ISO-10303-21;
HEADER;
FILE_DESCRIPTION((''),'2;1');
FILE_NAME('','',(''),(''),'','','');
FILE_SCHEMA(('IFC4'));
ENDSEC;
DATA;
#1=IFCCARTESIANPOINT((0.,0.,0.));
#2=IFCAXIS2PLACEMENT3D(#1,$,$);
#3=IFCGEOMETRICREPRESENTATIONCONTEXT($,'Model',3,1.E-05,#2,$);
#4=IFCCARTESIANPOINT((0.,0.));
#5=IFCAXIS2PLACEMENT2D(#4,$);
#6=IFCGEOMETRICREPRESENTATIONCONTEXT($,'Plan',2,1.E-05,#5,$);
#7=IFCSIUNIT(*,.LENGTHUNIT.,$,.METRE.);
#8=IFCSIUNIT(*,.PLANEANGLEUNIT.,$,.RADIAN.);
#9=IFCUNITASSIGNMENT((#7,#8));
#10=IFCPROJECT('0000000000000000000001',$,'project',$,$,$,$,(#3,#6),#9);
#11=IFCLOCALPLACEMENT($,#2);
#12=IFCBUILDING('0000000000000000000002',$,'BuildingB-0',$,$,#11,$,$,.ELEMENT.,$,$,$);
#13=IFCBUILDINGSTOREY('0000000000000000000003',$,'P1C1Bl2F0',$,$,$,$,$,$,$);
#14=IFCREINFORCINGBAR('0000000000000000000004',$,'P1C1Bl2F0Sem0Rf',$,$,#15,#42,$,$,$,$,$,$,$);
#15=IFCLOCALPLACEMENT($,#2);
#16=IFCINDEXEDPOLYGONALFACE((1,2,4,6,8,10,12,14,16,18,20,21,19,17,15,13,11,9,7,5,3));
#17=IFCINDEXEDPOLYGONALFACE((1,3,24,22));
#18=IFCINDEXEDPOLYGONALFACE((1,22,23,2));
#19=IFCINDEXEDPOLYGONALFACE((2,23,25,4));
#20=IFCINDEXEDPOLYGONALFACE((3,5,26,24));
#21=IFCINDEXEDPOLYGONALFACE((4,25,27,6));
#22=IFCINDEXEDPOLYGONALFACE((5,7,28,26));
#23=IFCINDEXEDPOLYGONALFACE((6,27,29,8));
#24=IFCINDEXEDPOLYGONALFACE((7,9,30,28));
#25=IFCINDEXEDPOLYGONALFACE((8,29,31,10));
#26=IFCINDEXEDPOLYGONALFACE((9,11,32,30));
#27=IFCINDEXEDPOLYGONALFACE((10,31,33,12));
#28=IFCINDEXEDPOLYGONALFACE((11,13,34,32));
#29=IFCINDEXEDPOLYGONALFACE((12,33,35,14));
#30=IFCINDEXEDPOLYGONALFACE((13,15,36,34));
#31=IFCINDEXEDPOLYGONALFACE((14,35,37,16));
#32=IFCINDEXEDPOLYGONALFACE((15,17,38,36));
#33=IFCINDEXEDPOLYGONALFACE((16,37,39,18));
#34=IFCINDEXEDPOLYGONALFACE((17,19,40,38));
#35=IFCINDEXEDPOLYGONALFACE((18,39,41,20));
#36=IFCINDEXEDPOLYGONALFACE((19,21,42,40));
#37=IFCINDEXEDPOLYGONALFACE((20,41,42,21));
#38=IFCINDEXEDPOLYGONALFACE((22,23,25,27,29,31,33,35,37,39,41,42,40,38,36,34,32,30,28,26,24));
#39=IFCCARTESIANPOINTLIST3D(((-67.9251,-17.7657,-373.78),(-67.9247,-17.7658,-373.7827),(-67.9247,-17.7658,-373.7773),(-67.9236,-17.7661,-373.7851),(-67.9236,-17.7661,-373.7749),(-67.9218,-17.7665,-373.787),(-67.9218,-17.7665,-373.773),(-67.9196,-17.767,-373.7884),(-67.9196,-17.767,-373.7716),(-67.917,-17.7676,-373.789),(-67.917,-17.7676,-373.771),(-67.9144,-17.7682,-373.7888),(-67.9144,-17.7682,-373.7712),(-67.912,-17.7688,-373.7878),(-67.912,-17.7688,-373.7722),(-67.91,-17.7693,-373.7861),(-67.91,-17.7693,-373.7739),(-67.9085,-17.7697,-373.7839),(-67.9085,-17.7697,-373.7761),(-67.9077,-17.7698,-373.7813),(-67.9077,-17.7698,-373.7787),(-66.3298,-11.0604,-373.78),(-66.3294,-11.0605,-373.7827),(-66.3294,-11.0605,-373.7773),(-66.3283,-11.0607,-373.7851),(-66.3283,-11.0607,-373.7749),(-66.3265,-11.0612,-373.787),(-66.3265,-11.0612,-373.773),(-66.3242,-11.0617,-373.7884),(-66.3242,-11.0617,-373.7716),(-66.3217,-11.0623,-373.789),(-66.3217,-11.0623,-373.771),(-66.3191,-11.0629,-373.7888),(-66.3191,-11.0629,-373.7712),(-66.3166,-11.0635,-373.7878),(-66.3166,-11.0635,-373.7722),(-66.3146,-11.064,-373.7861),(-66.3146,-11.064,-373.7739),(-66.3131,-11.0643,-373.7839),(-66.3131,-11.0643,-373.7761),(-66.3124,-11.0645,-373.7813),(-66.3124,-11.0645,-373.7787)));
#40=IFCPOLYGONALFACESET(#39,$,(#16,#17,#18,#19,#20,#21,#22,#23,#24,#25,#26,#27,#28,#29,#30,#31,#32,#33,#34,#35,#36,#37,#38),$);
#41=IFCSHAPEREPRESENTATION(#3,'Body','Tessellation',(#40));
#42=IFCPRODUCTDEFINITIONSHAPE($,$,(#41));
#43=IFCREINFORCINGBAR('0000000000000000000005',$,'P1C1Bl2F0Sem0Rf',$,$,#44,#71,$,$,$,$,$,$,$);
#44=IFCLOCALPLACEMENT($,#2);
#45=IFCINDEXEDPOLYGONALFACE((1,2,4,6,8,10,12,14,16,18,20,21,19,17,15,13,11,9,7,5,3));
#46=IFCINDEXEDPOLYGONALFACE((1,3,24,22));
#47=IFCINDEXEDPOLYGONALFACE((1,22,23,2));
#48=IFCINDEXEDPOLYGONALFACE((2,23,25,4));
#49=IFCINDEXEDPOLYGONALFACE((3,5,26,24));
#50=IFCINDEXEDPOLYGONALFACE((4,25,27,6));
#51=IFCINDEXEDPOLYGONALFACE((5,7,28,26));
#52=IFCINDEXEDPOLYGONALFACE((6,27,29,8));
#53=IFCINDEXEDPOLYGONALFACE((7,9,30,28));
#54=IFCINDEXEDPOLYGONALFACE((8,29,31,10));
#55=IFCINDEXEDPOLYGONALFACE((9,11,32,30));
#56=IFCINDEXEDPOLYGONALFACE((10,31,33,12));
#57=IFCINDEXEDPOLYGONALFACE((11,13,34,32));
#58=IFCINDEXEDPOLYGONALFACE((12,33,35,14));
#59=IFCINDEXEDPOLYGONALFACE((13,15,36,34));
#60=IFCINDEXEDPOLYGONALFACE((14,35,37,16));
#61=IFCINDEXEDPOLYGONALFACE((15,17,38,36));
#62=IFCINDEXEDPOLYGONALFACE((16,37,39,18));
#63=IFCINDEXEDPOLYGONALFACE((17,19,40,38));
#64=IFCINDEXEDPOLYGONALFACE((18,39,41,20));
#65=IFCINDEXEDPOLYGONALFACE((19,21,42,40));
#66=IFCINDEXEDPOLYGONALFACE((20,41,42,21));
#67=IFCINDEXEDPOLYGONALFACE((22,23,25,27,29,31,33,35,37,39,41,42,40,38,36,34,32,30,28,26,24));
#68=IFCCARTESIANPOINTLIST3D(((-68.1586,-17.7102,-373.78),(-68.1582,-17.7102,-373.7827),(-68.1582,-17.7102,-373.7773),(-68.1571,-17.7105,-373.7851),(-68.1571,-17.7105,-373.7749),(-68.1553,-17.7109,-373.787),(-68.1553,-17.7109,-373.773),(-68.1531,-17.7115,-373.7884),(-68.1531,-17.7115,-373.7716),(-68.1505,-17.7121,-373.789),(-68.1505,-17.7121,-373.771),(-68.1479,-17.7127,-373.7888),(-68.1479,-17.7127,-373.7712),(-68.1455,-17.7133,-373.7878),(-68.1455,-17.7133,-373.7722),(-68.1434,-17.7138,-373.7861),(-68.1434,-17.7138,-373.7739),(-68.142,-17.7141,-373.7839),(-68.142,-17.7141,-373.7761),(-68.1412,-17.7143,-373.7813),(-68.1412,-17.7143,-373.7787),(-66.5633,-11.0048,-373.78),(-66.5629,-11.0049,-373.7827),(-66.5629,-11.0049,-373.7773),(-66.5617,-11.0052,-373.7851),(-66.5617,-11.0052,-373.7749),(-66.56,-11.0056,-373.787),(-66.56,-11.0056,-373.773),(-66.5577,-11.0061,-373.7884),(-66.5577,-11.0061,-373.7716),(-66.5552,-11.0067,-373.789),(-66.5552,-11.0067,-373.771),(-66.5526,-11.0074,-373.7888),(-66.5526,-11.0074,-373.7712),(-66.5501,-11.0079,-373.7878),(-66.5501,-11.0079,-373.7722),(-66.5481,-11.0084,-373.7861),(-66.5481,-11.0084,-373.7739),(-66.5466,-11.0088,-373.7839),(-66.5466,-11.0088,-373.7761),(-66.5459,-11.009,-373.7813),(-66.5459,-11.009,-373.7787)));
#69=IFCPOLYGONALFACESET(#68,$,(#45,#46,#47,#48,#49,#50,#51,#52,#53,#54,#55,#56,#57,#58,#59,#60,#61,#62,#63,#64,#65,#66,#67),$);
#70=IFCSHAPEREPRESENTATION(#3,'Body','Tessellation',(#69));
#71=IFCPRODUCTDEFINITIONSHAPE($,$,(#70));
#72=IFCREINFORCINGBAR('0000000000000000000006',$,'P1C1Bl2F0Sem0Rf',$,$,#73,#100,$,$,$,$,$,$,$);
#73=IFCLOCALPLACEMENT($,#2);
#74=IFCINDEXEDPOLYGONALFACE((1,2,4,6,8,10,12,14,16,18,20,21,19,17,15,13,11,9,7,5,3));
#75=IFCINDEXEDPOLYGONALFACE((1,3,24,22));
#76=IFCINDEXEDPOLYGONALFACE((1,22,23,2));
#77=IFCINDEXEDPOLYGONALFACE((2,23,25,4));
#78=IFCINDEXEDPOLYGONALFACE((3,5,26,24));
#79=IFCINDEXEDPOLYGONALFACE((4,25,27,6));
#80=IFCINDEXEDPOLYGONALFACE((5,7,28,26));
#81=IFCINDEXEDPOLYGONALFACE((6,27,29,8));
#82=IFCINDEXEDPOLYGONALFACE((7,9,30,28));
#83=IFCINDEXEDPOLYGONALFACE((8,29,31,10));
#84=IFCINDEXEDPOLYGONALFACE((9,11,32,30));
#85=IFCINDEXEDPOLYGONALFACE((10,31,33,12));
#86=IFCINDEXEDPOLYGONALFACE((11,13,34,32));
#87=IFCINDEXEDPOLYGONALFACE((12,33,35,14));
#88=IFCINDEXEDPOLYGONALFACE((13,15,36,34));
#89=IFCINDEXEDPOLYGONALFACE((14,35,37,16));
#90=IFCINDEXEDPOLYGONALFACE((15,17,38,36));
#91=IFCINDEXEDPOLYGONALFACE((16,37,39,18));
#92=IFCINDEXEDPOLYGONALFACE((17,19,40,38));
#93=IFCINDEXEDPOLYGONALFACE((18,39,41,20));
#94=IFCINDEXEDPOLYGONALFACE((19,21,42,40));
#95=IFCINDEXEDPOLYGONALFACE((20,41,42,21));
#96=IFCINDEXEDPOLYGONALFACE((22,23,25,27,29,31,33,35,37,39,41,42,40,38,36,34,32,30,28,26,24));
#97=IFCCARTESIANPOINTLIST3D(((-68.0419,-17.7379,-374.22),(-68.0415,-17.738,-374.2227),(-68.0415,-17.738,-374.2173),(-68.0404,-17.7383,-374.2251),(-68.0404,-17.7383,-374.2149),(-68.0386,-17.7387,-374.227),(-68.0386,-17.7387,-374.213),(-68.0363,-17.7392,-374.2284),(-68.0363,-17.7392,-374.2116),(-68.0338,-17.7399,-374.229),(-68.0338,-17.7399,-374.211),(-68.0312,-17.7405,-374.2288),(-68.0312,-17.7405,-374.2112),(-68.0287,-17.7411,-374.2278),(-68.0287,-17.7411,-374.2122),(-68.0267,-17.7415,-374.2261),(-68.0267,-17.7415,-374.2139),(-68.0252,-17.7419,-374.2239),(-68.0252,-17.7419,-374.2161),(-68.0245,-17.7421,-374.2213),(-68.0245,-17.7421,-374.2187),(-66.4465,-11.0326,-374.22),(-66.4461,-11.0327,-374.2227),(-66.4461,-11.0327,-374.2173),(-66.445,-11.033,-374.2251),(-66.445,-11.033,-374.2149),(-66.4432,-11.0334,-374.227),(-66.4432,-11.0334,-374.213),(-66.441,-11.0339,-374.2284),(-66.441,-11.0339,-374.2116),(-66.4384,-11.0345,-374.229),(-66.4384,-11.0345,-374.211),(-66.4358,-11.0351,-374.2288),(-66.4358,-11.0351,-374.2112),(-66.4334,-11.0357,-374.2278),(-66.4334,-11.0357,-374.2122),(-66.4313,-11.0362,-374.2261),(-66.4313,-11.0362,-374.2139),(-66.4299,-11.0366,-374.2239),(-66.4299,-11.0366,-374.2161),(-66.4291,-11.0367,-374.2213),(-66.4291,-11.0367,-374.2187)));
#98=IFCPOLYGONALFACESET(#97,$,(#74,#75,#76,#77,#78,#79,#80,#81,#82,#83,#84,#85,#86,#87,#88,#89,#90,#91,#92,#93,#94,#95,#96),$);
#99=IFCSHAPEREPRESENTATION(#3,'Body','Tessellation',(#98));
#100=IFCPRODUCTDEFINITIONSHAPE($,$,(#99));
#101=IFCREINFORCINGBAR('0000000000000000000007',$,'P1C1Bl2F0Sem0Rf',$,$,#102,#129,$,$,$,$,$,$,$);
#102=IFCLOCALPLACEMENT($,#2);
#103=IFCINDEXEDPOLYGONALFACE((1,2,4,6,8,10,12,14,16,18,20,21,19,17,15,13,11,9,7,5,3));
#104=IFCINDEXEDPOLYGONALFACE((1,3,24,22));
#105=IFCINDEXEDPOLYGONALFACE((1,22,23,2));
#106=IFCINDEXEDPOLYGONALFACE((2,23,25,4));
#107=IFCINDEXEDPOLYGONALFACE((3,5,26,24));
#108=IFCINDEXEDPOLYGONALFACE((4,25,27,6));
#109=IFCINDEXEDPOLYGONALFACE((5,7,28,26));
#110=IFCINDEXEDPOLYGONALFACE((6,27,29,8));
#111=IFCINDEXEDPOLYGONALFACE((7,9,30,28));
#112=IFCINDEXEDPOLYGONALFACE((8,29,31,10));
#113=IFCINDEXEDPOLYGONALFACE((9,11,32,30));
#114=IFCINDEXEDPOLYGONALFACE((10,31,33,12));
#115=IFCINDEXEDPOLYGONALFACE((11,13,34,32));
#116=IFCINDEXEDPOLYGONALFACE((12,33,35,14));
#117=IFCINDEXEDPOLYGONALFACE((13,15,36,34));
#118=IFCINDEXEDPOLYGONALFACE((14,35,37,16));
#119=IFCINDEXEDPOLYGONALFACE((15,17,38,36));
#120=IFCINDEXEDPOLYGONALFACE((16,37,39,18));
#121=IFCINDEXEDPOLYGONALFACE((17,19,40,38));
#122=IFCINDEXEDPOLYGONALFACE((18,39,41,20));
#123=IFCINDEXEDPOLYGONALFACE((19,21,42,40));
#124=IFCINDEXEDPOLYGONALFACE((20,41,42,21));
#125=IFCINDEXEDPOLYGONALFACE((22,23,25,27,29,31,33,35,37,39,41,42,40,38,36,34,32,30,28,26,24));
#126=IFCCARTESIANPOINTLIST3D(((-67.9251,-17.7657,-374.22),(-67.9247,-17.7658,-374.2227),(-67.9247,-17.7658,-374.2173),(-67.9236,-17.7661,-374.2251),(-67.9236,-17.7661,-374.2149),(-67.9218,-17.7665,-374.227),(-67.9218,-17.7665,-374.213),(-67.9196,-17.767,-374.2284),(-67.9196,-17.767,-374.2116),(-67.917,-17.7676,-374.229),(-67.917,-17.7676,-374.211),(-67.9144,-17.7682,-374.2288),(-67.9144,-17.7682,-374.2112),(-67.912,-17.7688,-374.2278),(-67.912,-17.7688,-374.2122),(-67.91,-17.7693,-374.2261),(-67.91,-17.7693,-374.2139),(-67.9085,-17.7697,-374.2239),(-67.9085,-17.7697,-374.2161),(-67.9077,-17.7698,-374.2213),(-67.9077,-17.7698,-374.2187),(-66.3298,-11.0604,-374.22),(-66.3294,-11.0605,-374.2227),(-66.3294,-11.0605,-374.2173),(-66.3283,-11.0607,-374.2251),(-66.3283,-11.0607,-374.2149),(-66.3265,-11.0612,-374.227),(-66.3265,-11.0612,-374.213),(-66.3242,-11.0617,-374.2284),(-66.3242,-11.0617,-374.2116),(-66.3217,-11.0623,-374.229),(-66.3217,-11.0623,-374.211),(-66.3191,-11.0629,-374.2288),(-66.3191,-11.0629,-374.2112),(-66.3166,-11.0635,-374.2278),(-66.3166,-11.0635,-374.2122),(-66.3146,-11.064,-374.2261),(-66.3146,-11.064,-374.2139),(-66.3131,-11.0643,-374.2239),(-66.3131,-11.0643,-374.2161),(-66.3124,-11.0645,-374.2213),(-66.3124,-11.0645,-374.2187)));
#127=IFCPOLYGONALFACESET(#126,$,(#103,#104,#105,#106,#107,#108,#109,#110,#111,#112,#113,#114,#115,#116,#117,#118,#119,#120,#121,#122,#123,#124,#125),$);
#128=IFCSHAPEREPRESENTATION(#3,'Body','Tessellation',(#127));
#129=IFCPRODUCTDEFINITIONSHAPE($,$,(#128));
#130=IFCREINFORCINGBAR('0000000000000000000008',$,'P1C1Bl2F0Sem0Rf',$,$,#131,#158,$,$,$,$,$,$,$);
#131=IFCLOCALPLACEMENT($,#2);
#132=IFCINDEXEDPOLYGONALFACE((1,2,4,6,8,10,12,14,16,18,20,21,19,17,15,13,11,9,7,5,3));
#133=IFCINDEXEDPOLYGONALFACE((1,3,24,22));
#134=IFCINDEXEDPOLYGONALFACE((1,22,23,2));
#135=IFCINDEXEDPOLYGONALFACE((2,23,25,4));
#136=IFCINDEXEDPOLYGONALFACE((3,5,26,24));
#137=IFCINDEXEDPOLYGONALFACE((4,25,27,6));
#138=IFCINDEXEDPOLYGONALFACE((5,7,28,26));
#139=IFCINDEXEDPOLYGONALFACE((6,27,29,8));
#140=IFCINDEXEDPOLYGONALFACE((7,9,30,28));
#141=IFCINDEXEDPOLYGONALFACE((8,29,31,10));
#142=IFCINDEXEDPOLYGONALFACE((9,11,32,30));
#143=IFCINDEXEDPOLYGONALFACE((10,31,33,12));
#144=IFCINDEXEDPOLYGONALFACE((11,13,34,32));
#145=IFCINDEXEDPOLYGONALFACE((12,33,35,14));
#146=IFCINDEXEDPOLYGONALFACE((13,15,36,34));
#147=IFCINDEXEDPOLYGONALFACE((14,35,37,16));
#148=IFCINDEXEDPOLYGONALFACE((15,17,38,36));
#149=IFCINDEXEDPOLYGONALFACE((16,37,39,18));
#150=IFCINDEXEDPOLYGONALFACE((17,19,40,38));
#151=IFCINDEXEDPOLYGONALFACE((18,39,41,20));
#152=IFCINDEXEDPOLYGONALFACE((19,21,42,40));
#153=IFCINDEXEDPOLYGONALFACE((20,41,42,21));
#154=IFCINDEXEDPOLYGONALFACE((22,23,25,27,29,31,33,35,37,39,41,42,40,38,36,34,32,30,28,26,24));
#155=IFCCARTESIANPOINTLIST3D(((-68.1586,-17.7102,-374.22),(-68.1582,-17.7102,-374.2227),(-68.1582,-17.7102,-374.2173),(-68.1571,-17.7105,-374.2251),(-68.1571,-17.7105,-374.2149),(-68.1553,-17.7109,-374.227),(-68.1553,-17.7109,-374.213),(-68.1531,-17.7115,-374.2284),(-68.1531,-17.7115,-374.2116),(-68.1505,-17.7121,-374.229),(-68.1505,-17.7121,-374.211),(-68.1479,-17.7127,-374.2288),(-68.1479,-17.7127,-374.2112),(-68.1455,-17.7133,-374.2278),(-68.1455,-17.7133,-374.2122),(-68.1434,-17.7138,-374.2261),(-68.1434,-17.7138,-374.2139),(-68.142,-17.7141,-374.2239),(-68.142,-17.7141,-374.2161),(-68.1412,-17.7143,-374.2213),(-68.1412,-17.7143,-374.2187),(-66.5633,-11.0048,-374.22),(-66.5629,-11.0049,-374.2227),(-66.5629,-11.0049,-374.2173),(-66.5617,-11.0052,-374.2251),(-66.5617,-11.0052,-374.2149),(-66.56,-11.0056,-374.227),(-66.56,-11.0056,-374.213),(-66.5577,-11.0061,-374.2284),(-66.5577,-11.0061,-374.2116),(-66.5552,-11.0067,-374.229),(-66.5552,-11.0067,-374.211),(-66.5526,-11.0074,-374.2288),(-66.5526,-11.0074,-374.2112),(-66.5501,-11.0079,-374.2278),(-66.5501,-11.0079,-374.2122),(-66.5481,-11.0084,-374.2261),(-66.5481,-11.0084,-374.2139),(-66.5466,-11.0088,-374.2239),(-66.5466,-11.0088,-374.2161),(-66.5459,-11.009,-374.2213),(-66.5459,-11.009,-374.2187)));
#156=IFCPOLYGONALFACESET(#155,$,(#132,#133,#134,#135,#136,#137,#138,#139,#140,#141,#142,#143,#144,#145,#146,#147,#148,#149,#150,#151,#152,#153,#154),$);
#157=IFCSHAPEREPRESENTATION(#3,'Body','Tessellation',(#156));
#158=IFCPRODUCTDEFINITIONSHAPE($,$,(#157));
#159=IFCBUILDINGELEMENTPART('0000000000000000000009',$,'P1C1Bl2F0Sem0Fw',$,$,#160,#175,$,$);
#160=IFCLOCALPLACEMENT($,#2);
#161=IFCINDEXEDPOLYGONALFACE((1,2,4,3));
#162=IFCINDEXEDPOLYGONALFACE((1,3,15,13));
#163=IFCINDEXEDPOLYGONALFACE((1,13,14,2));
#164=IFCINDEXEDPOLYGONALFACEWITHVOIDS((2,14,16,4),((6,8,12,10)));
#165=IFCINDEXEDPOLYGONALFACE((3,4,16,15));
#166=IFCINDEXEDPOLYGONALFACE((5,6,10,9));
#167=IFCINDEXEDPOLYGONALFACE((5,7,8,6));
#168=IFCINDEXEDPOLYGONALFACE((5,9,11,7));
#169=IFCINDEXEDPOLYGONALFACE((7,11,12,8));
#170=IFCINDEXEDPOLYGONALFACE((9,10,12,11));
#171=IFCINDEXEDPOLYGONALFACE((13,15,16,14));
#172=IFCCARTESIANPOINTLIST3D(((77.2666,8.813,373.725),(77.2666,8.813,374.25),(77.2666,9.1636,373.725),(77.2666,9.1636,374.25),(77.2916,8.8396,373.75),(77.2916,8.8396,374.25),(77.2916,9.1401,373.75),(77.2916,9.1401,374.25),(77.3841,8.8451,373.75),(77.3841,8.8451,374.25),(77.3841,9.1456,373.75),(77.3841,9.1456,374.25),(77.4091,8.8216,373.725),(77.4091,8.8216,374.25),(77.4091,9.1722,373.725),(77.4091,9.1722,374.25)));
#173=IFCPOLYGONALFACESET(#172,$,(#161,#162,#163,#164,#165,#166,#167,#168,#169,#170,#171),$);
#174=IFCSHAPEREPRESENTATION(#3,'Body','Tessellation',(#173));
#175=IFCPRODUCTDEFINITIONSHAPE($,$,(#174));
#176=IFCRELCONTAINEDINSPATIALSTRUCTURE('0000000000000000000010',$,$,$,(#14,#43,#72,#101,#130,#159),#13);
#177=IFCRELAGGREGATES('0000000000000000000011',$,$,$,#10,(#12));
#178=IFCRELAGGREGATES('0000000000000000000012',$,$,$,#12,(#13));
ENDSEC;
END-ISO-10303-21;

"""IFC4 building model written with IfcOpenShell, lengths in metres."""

from ifc_helpers import new_model, entity, si_unit, origin, origin_2d, place, context, project, spatial, polyline, outline, extrude, element, save


model = new_model("IFC4")

# Units and contexts
model_context = context("Model", 3, precision=1e-05, world=origin())
plan_context = context("Plan", 2, precision=1e-05, world=origin_2d())
ifc_project = project(units=[si_unit("LENGTHUNIT", "METRE"), si_unit("PLANEANGLEUNIT", "RADIAN")], contexts=[model_context, plan_context])

# Building, storey
building_placement = place(None, origin())
building = spatial("IfcBuilding", under=ifc_project, at=building_placement, Name="BuildingB-0", CompositionType="ELEMENT")
storey = spatial("IfcBuildingStorey", under=building, Name="P1C1Bl2F0")

# Reinforcing bars
element("IfcReinforcingBar", 1, inside=storey, Name="P1C1Bl2F0Sem0Rf", context=model_context, shape_type="SweptSolid", body=[
    entity("IfcSurfaceCurveSweptAreaSolid", entity("IfcCircleProfileDef", "AREA", None, None, 0.009), None, entity("IfcPolyline", [entity("IfcCartesianPoint", [67.9164, 17.7678, 373.78]), entity("IfcCartesianPoint", [66.321, 11.0625, 373.78])]), None, None, entity("IfcPlane", entity("IfcAxis2Placement3D", entity("IfcCartesianPoint", [67.9164, 17.7678, 373.78]), entity("IfcDirection", [0.0, 0.0, 1.0]), entity("IfcDirection", [1.0, 0.0, 0.0])))),
])
element("IfcReinforcingBar", 2, inside=storey, Name="P1C1Bl2F0Sem0Rf", context=model_context, shape_type="SweptSolid", body=[
    entity("IfcSurfaceCurveSweptAreaSolid", entity("IfcCircleProfileDef", "AREA", None, None, 0.009), None, entity("IfcPolyline", [entity("IfcCartesianPoint", [68.1499, 17.7122, 373.78]), entity("IfcCartesianPoint", [66.5545, 11.0069, 373.78])]), None, None, entity("IfcPlane", entity("IfcAxis2Placement3D", entity("IfcCartesianPoint", [68.1499, 17.7122, 373.78]), entity("IfcDirection", [0.0, 0.0, 1.0]), entity("IfcDirection", [1.0, 0.0, 0.0])))),
])
element("IfcReinforcingBar", 3, inside=storey, Name="P1C1Bl2F0Sem0Rf", context=model_context, shape_type="SweptSolid", body=[
    entity("IfcSurfaceCurveSweptAreaSolid", entity("IfcCircleProfileDef", "AREA", None, None, 0.009), None, entity("IfcPolyline", [entity("IfcCartesianPoint", [68.0331, 17.74, 374.22]), entity("IfcCartesianPoint", [66.4378, 11.0347, 374.22])]), None, None, entity("IfcPlane", entity("IfcAxis2Placement3D", entity("IfcCartesianPoint", [68.0331, 17.74, 374.22]), entity("IfcDirection", [0.0, 0.0, 1.0]), entity("IfcDirection", [1.0, 0.0, 0.0])))),
])
element("IfcReinforcingBar", 4, inside=storey, Name="P1C1Bl2F0Sem0Rf", context=model_context, shape_type="SweptSolid", body=[
    entity("IfcSurfaceCurveSweptAreaSolid", entity("IfcCircleProfileDef", "AREA", None, None, 0.009), None, entity("IfcPolyline", [entity("IfcCartesianPoint", [67.9164, 17.7678, 374.22]), entity("IfcCartesianPoint", [66.321, 11.0625, 374.22])]), None, None, entity("IfcPlane", entity("IfcAxis2Placement3D", entity("IfcCartesianPoint", [67.9164, 17.7678, 374.22]), entity("IfcDirection", [0.0, 0.0, 1.0]), entity("IfcDirection", [1.0, 0.0, 0.0])))),
])
element("IfcReinforcingBar", 5, inside=storey, Name="P1C1Bl2F0Sem0Rf", context=model_context, shape_type="SweptSolid", body=[
    entity("IfcSurfaceCurveSweptAreaSolid", entity("IfcCircleProfileDef", "AREA", None, None, 0.009), None, entity("IfcPolyline", [entity("IfcCartesianPoint", [68.1499, 17.7122, 374.22]), entity("IfcCartesianPoint", [66.5545, 11.0069, 374.22])]), None, None, entity("IfcPlane", entity("IfcAxis2Placement3D", entity("IfcCartesianPoint", [68.1499, 17.7122, 374.22]), entity("IfcDirection", [0.0, 0.0, 1.0]), entity("IfcDirection", [1.0, 0.0, 0.0])))),
])

# Building element part, opening
building_element_part_1 = element("IfcBuildingElementPart", 6, inside=storey, Name="P1C1Bl2F0Sem0Fw", context=model_context, shape_type="SweptSolid", body=[
    extrude(outline(polyline([(77.4091, 8.8216, 373.725), (77.2666, 8.813, 373.725), (77.2666, 9.1636, 373.725), (77.4091, 9.1722, 373.725), (77.4091, 8.8216, 373.725)])), None, (0.0, 0.0, 1.0), 0.525),
])
element("IfcOpeningElement", 7, inside=storey, cuts=building_element_part_1, context=model_context, shape_type="SweptSolid", body=[
    extrude(outline(polyline([(77.3841, 8.8451, 373.75), (77.2916, 8.8396, 373.75), (77.2916, 9.1401, 373.75), (77.3841, 9.1456, 373.75), (77.3841, 8.8451, 373.75)])), None, (0.0, 0.0, 1.0), 0.5),
])

save(model, "model.ifc")
